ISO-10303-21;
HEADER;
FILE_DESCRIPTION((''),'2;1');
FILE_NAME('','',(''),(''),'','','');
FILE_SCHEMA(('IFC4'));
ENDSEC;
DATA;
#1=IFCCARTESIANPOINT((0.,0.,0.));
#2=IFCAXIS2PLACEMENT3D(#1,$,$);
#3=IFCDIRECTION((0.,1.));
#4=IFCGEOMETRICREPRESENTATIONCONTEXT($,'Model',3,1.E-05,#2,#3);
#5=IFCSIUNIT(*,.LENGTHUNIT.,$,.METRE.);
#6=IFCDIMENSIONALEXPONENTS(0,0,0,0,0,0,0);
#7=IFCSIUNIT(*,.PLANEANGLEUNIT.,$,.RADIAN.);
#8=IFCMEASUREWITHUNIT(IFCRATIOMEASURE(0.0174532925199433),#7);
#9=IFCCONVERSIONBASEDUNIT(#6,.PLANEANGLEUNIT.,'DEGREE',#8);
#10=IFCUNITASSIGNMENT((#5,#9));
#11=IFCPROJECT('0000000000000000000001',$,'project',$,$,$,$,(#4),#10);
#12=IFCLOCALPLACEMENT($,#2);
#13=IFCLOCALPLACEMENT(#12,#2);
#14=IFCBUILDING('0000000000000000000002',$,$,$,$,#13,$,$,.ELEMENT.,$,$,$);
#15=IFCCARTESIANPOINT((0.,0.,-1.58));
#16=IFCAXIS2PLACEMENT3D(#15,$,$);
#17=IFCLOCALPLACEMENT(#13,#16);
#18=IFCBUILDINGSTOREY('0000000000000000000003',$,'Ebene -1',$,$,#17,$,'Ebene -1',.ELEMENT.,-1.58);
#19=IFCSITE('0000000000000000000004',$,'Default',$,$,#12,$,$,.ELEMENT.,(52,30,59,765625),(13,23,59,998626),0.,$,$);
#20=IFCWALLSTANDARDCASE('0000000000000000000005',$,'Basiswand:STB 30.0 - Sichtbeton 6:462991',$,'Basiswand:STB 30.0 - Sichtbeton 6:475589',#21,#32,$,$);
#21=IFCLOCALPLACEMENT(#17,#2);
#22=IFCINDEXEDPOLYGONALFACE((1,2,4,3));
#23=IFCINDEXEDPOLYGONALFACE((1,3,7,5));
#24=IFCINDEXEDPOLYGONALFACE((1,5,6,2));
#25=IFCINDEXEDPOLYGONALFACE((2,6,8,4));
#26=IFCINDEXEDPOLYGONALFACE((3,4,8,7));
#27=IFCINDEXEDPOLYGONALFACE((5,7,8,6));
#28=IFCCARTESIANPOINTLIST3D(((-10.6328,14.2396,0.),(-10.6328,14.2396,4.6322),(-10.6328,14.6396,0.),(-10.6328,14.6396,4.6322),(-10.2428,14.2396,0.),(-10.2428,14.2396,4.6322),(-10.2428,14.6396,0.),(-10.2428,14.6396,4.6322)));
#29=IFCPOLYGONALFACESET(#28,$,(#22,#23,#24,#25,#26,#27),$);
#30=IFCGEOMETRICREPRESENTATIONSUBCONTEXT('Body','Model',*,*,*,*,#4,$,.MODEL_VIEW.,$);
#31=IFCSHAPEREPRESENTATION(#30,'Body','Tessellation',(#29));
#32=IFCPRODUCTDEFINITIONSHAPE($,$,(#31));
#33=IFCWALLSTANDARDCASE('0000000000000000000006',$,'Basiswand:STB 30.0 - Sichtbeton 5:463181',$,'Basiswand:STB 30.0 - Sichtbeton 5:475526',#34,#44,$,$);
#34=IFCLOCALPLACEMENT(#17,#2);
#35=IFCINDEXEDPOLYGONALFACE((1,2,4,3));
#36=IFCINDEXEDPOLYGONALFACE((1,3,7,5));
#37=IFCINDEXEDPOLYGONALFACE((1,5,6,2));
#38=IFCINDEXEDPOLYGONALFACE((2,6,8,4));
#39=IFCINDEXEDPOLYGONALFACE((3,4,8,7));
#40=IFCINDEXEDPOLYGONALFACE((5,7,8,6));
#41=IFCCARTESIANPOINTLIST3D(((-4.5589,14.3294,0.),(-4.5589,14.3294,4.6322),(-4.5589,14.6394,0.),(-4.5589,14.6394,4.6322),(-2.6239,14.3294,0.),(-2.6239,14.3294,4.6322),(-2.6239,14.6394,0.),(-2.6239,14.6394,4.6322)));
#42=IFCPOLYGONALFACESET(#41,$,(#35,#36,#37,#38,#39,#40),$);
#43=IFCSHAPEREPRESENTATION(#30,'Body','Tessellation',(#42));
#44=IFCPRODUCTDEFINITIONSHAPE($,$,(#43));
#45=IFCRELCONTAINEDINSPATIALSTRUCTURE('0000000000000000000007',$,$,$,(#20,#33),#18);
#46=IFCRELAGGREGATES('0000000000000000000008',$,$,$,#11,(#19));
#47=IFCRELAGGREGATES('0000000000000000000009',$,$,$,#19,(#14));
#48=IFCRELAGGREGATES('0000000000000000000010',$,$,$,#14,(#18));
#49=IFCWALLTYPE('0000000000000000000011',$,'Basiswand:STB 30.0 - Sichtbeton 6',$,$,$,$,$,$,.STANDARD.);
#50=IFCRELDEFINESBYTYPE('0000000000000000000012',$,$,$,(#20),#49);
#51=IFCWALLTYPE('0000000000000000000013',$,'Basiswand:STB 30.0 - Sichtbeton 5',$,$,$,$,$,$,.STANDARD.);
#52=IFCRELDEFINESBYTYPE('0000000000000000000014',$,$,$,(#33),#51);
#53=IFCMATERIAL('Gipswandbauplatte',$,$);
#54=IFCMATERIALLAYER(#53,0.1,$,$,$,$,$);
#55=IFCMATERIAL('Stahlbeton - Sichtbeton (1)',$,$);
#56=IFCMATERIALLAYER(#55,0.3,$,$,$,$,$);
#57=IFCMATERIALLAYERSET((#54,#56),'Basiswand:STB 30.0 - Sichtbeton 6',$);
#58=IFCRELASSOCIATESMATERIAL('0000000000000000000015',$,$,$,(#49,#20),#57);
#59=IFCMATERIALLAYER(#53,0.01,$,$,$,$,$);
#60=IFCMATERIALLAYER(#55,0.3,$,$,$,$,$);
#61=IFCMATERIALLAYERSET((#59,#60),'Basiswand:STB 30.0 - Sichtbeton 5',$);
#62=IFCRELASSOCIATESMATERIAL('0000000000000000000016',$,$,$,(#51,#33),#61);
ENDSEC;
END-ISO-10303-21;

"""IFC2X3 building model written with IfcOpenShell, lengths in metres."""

from ifc_helpers import new_model, entity, si_unit, converted_unit, direction, frame, frame_2d, origin, place, context, subcontext, project, spatial, rectangle, extrude, material, layer, layer_set, layer_usage, type_object, element, save


model = new_model("IFC2X3")

# Units and contexts
model_context = context("Model", 3, precision=1e-05, world=origin(), true_north=direction((0.0, 1.0)))
body_context = subcontext(model_context, "Body", "Model", "MODEL_VIEW")
ifc_project = project(units=[si_unit("LENGTHUNIT", "METRE"), converted_unit("PLANEANGLEUNIT", "DEGREE", entity("IfcRatioMeasure", 0.0174532925199433), si_unit("PLANEANGLEUNIT", "RADIAN"), dimensions=[0, 0, 0, 0, 0, 0, 0])], contexts=[model_context])

# Site, building, storey
site_placement = place(None, origin())
site = spatial("IfcSite", under=ifc_project, at=site_placement, Name="Default", CompositionType="ELEMENT", RefLatitude=(52, 30, 59, 765625), RefLongitude=(13, 23, 59, 998626), RefElevation=0.0)
building_placement = place(site_placement, origin())
building = spatial("IfcBuilding", under=site, at=building_placement, CompositionType="ELEMENT")
storey_placement = place(building_placement, frame((0.0, 0.0, -1.58)))
storey = spatial("IfcBuildingStorey", under=building, at=storey_placement, Name="Ebene -1", LongName="Ebene -1", CompositionType="ELEMENT", Elevation=-1.58)

# Shared definitions
ifc_material_1 = material(Name="Stahlbeton - Sichtbeton (1)")
ifc_material_2 = material(Name="Gipswandbauplatte")

# Walls
ifc_layer_1 = layer(ifc_material_2, 0.1)
ifc_layer_2 = layer(ifc_material_1, 0.3)
ifc_layer_set_1 = layer_set([ifc_layer_1, ifc_layer_2], Name="Basiswand:STB 30.0 - Sichtbeton 6")
ifc_layer_usage_1 = layer_usage(ifc_layer_set_1, "AXIS2", "NEGATIVE", 0.2)
wall_type_1 = type_object("IfcWallType", Name="Basiswand:STB 30.0 - Sichtbeton 6", PredefinedType="STANDARD", material=ifc_layer_set_1)
wall_1_placement = place(storey_placement, frame((-10.2428, 14.4396, 0.0), z_axis=(0.0, 0.0, 1.0), x_axis=(-1.0, 0.0, 0.0)))
element("IfcWallStandardCase", 1, at=wall_1_placement, inside=storey, type_object=wall_type_1, material=ifc_layer_usage_1, Name="Basiswand:STB 30.0 - Sichtbeton 6:462991", ObjectType="Basiswand:STB 30.0 - Sichtbeton 6:475589", context=body_context, shape_type="SweptSolid", body=[
    extrude(rectangle(XDim=0.39, YDim=0.4, at=frame_2d((0.195, 0.0), x_axis=(-1.0, 0.0))), origin(), (0.0, 0.0, 1.0), 4.6322),
])
ifc_layer_3 = layer(ifc_material_2, 0.01)
ifc_layer_4 = layer(ifc_material_1, 0.3)
ifc_layer_set_2 = layer_set([ifc_layer_3, ifc_layer_4], Name="Basiswand:STB 30.0 - Sichtbeton 5")
ifc_layer_usage_2 = layer_usage(ifc_layer_set_2, "AXIS2", "NEGATIVE", 0.155)
wall_type_2 = type_object("IfcWallType", Name="Basiswand:STB 30.0 - Sichtbeton 5", PredefinedType="STANDARD", material=ifc_layer_set_2)
wall_2_placement = place(storey_placement, frame((-2.6239, 14.4844, 0.0), z_axis=(0.0, 0.0, 1.0), x_axis=(-1.0, 0.0, 0.0)))
element("IfcWallStandardCase", 2, at=wall_2_placement, inside=storey, type_object=wall_type_2, material=ifc_layer_usage_2, Name="Basiswand:STB 30.0 - Sichtbeton 5:463181", ObjectType="Basiswand:STB 30.0 - Sichtbeton 5:475526", context=body_context, shape_type="SweptSolid", body=[
    extrude(rectangle(XDim=1.9349, YDim=0.31, at=frame_2d((0.9675, 0.0), x_axis=(-1.0, 0.0))), origin(), (0.0, 0.0, 1.0), 4.6322),
])

save(model, "model.ifc")
